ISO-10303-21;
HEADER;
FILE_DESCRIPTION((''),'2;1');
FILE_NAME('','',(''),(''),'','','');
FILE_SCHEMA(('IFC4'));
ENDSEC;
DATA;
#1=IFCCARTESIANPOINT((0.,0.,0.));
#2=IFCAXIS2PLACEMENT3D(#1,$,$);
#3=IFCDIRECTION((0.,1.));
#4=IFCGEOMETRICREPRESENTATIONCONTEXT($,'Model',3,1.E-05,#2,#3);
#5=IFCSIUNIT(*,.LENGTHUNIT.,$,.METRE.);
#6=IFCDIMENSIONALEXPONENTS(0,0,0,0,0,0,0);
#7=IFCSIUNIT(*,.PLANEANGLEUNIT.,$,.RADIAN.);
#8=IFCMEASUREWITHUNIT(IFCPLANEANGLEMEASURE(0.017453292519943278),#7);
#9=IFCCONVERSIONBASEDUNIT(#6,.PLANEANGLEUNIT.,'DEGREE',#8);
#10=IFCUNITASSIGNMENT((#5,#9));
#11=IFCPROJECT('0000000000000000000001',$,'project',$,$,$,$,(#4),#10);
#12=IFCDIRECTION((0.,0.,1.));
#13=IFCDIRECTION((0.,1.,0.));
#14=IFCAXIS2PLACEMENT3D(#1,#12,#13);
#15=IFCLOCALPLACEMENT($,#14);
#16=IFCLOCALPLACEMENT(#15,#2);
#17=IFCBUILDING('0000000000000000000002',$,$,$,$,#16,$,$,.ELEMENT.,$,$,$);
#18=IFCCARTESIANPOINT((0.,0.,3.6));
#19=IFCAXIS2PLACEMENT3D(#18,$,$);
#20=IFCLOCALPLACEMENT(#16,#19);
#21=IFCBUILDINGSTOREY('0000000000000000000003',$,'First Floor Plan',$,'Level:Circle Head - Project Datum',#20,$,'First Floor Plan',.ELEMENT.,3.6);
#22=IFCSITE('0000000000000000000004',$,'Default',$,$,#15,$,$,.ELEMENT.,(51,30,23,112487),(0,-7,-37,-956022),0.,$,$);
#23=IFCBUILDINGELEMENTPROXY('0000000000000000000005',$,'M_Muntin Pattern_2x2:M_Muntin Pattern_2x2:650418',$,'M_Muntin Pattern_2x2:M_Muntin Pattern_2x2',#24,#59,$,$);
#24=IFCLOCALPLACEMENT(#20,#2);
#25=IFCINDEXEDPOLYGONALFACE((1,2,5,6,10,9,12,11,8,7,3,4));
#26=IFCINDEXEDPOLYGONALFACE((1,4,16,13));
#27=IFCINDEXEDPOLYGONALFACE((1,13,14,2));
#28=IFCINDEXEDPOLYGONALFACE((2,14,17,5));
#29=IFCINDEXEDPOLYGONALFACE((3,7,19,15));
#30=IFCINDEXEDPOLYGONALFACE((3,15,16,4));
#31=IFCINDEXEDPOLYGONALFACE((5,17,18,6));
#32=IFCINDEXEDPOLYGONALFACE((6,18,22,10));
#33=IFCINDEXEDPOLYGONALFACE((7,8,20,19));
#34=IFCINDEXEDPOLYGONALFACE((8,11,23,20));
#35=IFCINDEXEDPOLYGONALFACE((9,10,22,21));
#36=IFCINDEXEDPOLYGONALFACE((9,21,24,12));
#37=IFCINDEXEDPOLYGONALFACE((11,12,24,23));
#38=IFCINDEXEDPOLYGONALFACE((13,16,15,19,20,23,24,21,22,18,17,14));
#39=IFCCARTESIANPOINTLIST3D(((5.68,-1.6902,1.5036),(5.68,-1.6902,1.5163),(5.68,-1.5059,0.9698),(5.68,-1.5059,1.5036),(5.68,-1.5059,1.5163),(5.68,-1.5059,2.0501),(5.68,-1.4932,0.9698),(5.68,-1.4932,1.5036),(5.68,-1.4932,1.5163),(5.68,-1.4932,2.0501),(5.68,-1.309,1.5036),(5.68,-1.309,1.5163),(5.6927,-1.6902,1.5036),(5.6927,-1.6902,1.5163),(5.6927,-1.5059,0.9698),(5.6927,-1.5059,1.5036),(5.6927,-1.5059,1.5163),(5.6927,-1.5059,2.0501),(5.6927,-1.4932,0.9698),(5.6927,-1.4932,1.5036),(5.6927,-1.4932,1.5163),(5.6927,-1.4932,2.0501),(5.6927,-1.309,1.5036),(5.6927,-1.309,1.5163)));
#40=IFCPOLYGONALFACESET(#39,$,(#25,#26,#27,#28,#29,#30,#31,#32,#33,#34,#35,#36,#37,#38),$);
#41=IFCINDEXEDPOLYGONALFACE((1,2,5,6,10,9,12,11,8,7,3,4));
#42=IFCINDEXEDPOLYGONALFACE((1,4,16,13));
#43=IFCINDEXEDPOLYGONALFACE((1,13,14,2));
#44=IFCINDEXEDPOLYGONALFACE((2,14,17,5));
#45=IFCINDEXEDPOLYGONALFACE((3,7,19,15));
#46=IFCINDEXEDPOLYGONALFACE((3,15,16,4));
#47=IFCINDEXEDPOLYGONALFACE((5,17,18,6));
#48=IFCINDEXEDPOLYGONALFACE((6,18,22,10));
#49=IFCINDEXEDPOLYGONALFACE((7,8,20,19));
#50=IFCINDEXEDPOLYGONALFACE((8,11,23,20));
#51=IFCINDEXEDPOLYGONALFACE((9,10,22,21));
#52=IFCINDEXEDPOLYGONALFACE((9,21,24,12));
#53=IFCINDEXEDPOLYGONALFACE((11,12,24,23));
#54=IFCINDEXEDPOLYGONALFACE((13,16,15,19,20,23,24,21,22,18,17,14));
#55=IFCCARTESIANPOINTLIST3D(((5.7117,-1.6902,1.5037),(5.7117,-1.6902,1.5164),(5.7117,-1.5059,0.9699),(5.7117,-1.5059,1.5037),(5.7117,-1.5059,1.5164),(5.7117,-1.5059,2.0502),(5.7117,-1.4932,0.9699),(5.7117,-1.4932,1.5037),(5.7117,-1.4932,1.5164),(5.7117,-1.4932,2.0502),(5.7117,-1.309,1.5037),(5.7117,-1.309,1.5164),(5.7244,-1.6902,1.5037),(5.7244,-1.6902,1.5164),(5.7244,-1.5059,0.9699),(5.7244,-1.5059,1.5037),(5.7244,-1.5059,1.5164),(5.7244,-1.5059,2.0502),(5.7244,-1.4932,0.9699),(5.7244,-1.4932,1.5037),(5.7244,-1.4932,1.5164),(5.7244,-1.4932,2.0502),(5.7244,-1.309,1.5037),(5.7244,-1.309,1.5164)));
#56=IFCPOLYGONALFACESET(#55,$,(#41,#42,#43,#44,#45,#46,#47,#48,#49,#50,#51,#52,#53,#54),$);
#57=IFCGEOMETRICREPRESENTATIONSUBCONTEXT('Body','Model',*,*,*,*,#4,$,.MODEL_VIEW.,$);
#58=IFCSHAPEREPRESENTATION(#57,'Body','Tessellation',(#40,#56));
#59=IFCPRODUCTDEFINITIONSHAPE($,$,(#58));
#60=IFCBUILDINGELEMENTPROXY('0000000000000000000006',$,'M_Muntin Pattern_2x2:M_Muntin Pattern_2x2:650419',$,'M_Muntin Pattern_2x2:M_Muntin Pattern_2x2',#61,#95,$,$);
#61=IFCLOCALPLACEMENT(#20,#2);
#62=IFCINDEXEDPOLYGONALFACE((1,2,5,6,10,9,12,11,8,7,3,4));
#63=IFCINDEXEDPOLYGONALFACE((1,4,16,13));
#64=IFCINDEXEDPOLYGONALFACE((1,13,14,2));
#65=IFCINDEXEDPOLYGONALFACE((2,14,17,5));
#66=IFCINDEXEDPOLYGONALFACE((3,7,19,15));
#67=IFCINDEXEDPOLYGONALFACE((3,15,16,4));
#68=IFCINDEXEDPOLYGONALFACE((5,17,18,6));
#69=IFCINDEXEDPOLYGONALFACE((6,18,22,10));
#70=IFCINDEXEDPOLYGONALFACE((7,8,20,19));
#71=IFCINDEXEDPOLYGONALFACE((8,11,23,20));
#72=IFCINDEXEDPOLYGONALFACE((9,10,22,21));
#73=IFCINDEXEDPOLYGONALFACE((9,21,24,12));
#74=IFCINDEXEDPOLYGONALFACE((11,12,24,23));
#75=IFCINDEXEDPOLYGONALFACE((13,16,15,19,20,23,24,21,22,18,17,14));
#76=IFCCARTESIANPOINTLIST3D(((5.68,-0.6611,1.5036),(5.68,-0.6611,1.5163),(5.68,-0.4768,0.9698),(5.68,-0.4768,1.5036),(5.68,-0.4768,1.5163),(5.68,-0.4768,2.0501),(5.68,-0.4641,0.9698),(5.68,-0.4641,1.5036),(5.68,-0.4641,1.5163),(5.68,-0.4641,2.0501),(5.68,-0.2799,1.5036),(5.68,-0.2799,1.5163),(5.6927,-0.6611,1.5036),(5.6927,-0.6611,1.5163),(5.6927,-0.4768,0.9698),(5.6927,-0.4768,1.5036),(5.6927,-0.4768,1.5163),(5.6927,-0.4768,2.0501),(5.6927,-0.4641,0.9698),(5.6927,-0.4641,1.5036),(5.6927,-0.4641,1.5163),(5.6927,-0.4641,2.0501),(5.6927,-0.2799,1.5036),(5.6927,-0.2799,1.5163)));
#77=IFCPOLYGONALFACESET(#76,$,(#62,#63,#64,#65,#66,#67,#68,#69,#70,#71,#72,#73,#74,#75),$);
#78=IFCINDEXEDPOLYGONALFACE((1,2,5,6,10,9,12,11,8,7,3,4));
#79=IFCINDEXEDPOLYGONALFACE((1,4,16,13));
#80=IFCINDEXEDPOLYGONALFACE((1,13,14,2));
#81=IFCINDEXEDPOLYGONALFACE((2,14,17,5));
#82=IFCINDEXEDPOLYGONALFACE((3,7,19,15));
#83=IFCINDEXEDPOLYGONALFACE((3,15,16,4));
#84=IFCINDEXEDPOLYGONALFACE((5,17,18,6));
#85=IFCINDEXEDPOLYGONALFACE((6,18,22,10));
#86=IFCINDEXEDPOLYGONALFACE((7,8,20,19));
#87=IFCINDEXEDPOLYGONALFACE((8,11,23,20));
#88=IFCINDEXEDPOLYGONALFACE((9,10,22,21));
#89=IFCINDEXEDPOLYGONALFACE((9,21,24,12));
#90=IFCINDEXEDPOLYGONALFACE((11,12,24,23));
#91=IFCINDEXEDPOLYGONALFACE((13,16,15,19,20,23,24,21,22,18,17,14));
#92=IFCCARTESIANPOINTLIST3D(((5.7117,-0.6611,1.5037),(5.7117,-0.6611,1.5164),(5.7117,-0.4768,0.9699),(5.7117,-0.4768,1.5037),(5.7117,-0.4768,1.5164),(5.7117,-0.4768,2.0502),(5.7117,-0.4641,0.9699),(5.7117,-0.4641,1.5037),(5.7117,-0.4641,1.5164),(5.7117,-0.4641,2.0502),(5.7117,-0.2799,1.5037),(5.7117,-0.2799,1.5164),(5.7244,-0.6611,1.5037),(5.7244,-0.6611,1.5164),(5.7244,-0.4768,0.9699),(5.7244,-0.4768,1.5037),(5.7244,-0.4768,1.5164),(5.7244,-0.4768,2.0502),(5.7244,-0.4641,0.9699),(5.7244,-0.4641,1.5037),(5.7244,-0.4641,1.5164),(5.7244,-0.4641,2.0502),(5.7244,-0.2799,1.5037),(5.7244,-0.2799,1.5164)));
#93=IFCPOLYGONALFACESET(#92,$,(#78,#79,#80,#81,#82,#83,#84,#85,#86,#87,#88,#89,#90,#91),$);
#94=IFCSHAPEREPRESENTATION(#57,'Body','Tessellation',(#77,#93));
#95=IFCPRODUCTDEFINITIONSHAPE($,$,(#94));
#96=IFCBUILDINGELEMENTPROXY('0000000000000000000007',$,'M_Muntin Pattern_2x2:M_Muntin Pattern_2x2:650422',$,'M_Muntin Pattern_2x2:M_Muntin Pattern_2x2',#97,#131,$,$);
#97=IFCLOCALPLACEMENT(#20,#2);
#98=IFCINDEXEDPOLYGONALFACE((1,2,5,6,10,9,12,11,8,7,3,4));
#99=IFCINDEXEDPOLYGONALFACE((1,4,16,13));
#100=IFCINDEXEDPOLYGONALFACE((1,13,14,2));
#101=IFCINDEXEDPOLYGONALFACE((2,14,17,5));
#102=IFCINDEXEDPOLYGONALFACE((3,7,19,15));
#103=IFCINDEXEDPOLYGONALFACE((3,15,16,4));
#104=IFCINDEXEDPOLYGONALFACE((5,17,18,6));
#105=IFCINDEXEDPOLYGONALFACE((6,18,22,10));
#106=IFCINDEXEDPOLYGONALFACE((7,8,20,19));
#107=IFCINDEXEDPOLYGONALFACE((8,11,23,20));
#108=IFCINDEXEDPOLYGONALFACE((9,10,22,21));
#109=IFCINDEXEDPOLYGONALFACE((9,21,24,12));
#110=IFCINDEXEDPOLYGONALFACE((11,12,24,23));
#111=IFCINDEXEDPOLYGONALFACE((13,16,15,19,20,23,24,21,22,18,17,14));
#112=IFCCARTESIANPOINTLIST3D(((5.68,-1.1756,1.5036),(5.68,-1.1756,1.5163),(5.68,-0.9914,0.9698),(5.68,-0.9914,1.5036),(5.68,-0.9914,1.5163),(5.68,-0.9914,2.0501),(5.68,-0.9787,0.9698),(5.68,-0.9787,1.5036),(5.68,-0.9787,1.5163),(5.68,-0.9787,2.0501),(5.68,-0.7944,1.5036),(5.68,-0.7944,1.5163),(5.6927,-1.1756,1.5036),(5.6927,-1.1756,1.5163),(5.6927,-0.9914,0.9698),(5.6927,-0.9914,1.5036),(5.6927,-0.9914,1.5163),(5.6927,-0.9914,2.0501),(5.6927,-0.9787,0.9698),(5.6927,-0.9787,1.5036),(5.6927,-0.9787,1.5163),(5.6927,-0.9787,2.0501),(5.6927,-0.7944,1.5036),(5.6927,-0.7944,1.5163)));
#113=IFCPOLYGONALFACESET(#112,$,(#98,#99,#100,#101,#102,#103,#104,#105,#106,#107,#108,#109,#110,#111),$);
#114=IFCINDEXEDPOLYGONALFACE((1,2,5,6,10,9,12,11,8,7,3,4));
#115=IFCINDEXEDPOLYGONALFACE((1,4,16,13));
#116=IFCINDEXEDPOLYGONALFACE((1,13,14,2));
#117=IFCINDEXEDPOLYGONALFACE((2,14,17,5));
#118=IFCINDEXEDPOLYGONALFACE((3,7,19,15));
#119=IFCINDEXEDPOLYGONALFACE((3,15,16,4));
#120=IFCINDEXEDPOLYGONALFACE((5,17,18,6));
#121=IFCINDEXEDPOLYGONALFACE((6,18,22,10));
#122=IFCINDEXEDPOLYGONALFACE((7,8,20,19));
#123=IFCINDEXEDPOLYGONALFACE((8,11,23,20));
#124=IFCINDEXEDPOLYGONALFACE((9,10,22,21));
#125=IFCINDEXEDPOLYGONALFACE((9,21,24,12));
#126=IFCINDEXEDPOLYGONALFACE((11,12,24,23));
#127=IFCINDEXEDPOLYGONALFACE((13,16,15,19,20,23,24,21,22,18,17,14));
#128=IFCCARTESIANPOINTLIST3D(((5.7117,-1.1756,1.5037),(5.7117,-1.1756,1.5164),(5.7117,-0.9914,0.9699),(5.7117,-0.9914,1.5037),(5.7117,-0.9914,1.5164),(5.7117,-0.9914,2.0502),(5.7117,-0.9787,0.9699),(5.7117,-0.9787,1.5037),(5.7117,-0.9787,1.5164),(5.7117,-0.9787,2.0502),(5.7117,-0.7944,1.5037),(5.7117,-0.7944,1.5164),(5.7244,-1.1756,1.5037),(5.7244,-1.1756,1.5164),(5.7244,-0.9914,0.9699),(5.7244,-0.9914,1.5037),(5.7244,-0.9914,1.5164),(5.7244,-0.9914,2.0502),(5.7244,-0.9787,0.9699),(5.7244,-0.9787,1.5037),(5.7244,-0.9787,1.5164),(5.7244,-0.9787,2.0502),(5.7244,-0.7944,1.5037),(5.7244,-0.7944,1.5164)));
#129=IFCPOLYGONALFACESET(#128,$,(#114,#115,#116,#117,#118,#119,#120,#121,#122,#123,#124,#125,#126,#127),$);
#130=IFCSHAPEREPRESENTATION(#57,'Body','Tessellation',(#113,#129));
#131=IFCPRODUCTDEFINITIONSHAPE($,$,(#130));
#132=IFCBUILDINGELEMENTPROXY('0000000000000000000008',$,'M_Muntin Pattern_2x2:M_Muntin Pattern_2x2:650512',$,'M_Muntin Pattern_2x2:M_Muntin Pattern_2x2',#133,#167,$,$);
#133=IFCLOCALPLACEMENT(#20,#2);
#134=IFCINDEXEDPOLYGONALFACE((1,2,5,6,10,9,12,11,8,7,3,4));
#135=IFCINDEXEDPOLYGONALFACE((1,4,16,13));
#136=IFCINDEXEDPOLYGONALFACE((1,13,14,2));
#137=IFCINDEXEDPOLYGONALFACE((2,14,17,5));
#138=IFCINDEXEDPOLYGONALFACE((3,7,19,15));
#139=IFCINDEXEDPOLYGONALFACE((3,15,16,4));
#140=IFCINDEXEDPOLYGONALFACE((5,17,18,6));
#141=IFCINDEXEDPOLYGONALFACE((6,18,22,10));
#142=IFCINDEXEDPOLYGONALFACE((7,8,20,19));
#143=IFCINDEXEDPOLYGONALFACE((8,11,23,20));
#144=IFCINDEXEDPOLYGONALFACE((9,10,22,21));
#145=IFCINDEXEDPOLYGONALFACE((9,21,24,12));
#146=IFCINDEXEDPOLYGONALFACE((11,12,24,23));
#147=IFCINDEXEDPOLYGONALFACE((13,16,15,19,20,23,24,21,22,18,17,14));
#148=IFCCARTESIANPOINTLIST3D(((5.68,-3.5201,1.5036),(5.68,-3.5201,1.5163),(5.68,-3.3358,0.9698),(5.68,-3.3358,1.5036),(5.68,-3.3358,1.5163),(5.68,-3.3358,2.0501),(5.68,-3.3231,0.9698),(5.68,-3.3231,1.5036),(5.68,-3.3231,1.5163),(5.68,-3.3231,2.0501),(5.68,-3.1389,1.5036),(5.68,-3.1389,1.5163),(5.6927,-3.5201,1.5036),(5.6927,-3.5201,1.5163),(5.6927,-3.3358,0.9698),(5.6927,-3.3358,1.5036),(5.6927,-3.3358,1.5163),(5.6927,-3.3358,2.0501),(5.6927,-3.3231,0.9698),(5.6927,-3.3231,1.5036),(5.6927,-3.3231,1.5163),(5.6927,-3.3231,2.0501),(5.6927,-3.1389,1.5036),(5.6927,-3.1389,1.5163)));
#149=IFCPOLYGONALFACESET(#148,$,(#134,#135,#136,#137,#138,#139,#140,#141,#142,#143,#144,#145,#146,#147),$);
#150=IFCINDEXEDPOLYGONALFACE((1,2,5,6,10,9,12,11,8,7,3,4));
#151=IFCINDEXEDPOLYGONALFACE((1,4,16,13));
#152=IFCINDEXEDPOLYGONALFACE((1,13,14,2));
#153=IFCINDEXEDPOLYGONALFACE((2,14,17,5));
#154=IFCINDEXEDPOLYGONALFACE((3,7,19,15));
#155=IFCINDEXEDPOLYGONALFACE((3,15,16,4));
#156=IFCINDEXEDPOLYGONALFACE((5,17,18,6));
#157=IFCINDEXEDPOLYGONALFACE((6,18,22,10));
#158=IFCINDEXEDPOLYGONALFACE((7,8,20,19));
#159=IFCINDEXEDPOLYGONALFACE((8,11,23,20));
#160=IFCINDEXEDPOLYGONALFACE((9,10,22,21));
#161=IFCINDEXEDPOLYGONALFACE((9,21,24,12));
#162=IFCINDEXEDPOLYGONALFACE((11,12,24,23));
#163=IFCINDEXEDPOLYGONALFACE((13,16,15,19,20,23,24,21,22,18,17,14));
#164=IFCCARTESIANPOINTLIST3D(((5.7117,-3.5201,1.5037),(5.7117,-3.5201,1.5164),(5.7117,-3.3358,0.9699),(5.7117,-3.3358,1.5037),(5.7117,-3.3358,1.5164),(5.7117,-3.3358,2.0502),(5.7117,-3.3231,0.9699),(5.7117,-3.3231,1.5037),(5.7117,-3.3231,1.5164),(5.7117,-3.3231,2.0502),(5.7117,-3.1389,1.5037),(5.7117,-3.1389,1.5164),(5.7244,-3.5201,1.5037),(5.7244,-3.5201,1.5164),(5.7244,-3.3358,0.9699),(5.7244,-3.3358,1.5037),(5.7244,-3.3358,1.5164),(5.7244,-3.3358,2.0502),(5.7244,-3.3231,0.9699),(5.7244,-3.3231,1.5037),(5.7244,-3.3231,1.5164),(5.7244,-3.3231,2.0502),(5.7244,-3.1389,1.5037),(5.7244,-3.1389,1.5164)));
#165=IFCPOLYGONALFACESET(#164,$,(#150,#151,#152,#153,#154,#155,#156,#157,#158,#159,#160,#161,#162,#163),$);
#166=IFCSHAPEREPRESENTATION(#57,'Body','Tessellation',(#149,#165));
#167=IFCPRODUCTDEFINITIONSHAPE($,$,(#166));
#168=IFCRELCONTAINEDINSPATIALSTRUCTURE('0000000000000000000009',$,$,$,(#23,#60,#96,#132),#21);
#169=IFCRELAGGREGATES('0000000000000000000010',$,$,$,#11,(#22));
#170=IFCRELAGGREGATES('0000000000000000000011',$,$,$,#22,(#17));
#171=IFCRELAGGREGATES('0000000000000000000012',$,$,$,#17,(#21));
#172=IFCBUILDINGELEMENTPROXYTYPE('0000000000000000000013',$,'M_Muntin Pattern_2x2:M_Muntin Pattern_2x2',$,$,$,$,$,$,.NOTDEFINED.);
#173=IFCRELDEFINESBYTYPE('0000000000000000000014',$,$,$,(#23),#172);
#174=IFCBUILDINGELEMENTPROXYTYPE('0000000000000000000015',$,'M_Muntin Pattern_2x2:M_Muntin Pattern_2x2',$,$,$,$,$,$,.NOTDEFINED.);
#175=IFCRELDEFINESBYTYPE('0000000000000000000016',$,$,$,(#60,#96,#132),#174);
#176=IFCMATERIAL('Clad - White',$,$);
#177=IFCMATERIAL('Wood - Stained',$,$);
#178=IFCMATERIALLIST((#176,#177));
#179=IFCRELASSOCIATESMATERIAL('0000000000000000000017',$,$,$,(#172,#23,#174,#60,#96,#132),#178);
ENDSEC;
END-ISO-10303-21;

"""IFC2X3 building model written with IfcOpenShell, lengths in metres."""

from ifc_helpers import new_model, entity, si_unit, converted_unit, direction, frame, origin, place, context, subcontext, project, spatial, polyline, outline, extrude, source, transform, mapped, material, material_list, type_object, type_shapes, element, save


model = new_model("IFC2X3")

# Units and contexts
model_context = context("Model", 3, precision=1e-05, world=origin(), true_north=direction((0.0, 1.0)))
body_context = subcontext(model_context, "Body", "Model", "MODEL_VIEW")
ifc_project = project(units=[si_unit("LENGTHUNIT", "METRE"), converted_unit("PLANEANGLEUNIT", "DEGREE", entity("IfcPlaneAngleMeasure", 0.017453292519943278), si_unit("PLANEANGLEUNIT", "RADIAN"), dimensions=[0, 0, 0, 0, 0, 0, 0])], contexts=[model_context])

# Site, building, storey
site_placement = place(None, frame((0.0, 0.0, 0.0), z_axis=(0.0, 0.0, 1.0), x_axis=(0.0, 1.0, 0.0)))
site = spatial("IfcSite", under=ifc_project, at=site_placement, Name="Default", CompositionType="ELEMENT", RefLatitude=(51, 30, 23, 112487), RefLongitude=(0, -7, -37, -956022), RefElevation=0.0)
building_placement = place(site_placement, origin())
building = spatial("IfcBuilding", under=site, at=building_placement, CompositionType="ELEMENT")
storey_placement = place(building_placement, frame((0.0, 0.0, 3.6)))
storey = spatial("IfcBuildingStorey", under=building, at=storey_placement, Name="First Floor Plan", ObjectType="Level:Circle Head - Project Datum", LongName="First Floor Plan", CompositionType="ELEMENT", Elevation=3.6)

# Building element proxies
ifc_material_1 = material(Name="Clad - White")
ifc_material_2 = material(Name="Wood - Stained")
ifc_material_list = material_list([ifc_material_1, ifc_material_2])
building_element_proxy_type_1 = type_object("IfcBuildingElementProxyType", Name="M_Muntin Pattern_2x2:M_Muntin Pattern_2x2", PredefinedType="NOTDEFINED", material=ifc_material_list)
shared_shape_1 = source(origin(), body_context, "Body", "SweptSolid", [
    extrude(outline(polyline([(0.0064, -0.0064), (0.5401, -0.0064), (0.5401, 0.0063), (0.0064, 0.0063), (0.0064, 0.1906), (-0.0063, 0.1906), (-0.0063, 0.0063), (-0.5402, 0.0063), (-0.5402, -0.0064), (-0.0063, -0.0064), (-0.0063, -0.1906), (0.0064, -0.1906), (0.0064, -0.0064)])), frame((0.0, 0.0095, 0.5401), z_axis=(0.0, 1.0, 0.0), x_axis=(0.0, 0.0, 1.0)), (0.0, 0.0, 1.0), 0.0127),
    extrude(outline(polyline([(0.0064, -0.0064), (0.5402, -0.0064), (0.5402, 0.0063), (0.0064, 0.0063), (0.0064, 0.1906), (-0.0063, 0.1906), (-0.0063, 0.0063), (-0.5402, 0.0063), (-0.5402, -0.0064), (-0.0063, -0.0064), (-0.0063, -0.1906), (0.0064, -0.1906), (0.0064, -0.0064)])), frame((0.0, -0.0222, 0.5402), z_axis=(0.0, 1.0, 0.0), x_axis=(0.0, 0.0, 1.0)), (0.0, 0.0, 1.0), 0.0127),
])
type_shapes(building_element_proxy_type_1, [shared_shape_1])
proxy_1_placement = place(storey_placement, frame((5.7022, -1.4996, 0.9699), z_axis=(0.0, 0.0, 1.0), x_axis=(0.0, 1.0, 0.0)))
element("IfcBuildingElementProxy", 1, at=proxy_1_placement, inside=storey, type_object=building_element_proxy_type_1, material=ifc_material_list, Name="M_Muntin Pattern_2x2:M_Muntin Pattern_2x2:650418", ObjectType="M_Muntin Pattern_2x2:M_Muntin Pattern_2x2", context=body_context, shape_type="MappedRepresentation", body=[
    mapped(shared_shape_1, transform((0.0, 0.0, 0.0), scale=1.0)),
])
building_element_proxy_type_2 = type_object("IfcBuildingElementProxyType", Name="M_Muntin Pattern_2x2:M_Muntin Pattern_2x2", PredefinedType="NOTDEFINED", material=ifc_material_list)
shared_shape_2 = source(origin(), body_context, "Body", "SweptSolid", [
    extrude(outline(polyline([(0.0064, -0.0064), (0.5401, -0.0064), (0.5401, 0.0063), (0.0064, 0.0063), (0.0064, 0.1906), (-0.0063, 0.1906), (-0.0063, 0.0063), (-0.5402, 0.0063), (-0.5402, -0.0064), (-0.0063, -0.0064), (-0.0063, -0.1906), (0.0064, -0.1906), (0.0064, -0.0064)])), frame((0.0, -0.0222, 0.5401), z_axis=(0.0, 1.0, 0.0), x_axis=(0.0, 0.0, 1.0)), (0.0, 0.0, 1.0), 0.0127),
    extrude(outline(polyline([(0.0064, -0.0064), (0.5402, -0.0064), (0.5402, 0.0063), (0.0064, 0.0063), (0.0064, 0.1906), (-0.0063, 0.1906), (-0.0063, 0.0063), (-0.5402, 0.0063), (-0.5402, -0.0064), (-0.0063, -0.0064), (-0.0063, -0.1906), (0.0064, -0.1906), (0.0064, -0.0064)])), frame((0.0, 0.0095, 0.5402), z_axis=(0.0, 1.0, 0.0), x_axis=(0.0, 0.0, 1.0)), (0.0, 0.0, 1.0), 0.0127),
])
type_shapes(building_element_proxy_type_2, [shared_shape_2])
for number, where, z_axis, x_axis, name in (
    (2, (5.7022, -0.4705, 0.9699), (0.0, 0.0, 1.0), (0.0, -1.0, 0.0), "M_Muntin Pattern_2x2:M_Muntin Pattern_2x2:650419"),
    (3, (5.7022, -0.985, 0.9699), (0.0, 0.0, 1.0), (0.0, -1.0, 0.0), "M_Muntin Pattern_2x2:M_Muntin Pattern_2x2:650422"),
    (4, (5.7022, -3.3295, 0.9699), (0.0, 0.0, 1.0), (0.0, -1.0, 0.0), "M_Muntin Pattern_2x2:M_Muntin Pattern_2x2:650512"),
):
    element("IfcBuildingElementProxy", number, at=place(storey_placement, frame(where, z_axis=z_axis, x_axis=x_axis)), inside=storey, type_object=building_element_proxy_type_2, material=ifc_material_list, Name=name, ObjectType="M_Muntin Pattern_2x2:M_Muntin Pattern_2x2", context=body_context, shape_type="MappedRepresentation", body=[
        mapped(shared_shape_2, transform((0.0, 0.0, 0.0), scale=1.0)),
    ])

save(model, "model.ifc")
